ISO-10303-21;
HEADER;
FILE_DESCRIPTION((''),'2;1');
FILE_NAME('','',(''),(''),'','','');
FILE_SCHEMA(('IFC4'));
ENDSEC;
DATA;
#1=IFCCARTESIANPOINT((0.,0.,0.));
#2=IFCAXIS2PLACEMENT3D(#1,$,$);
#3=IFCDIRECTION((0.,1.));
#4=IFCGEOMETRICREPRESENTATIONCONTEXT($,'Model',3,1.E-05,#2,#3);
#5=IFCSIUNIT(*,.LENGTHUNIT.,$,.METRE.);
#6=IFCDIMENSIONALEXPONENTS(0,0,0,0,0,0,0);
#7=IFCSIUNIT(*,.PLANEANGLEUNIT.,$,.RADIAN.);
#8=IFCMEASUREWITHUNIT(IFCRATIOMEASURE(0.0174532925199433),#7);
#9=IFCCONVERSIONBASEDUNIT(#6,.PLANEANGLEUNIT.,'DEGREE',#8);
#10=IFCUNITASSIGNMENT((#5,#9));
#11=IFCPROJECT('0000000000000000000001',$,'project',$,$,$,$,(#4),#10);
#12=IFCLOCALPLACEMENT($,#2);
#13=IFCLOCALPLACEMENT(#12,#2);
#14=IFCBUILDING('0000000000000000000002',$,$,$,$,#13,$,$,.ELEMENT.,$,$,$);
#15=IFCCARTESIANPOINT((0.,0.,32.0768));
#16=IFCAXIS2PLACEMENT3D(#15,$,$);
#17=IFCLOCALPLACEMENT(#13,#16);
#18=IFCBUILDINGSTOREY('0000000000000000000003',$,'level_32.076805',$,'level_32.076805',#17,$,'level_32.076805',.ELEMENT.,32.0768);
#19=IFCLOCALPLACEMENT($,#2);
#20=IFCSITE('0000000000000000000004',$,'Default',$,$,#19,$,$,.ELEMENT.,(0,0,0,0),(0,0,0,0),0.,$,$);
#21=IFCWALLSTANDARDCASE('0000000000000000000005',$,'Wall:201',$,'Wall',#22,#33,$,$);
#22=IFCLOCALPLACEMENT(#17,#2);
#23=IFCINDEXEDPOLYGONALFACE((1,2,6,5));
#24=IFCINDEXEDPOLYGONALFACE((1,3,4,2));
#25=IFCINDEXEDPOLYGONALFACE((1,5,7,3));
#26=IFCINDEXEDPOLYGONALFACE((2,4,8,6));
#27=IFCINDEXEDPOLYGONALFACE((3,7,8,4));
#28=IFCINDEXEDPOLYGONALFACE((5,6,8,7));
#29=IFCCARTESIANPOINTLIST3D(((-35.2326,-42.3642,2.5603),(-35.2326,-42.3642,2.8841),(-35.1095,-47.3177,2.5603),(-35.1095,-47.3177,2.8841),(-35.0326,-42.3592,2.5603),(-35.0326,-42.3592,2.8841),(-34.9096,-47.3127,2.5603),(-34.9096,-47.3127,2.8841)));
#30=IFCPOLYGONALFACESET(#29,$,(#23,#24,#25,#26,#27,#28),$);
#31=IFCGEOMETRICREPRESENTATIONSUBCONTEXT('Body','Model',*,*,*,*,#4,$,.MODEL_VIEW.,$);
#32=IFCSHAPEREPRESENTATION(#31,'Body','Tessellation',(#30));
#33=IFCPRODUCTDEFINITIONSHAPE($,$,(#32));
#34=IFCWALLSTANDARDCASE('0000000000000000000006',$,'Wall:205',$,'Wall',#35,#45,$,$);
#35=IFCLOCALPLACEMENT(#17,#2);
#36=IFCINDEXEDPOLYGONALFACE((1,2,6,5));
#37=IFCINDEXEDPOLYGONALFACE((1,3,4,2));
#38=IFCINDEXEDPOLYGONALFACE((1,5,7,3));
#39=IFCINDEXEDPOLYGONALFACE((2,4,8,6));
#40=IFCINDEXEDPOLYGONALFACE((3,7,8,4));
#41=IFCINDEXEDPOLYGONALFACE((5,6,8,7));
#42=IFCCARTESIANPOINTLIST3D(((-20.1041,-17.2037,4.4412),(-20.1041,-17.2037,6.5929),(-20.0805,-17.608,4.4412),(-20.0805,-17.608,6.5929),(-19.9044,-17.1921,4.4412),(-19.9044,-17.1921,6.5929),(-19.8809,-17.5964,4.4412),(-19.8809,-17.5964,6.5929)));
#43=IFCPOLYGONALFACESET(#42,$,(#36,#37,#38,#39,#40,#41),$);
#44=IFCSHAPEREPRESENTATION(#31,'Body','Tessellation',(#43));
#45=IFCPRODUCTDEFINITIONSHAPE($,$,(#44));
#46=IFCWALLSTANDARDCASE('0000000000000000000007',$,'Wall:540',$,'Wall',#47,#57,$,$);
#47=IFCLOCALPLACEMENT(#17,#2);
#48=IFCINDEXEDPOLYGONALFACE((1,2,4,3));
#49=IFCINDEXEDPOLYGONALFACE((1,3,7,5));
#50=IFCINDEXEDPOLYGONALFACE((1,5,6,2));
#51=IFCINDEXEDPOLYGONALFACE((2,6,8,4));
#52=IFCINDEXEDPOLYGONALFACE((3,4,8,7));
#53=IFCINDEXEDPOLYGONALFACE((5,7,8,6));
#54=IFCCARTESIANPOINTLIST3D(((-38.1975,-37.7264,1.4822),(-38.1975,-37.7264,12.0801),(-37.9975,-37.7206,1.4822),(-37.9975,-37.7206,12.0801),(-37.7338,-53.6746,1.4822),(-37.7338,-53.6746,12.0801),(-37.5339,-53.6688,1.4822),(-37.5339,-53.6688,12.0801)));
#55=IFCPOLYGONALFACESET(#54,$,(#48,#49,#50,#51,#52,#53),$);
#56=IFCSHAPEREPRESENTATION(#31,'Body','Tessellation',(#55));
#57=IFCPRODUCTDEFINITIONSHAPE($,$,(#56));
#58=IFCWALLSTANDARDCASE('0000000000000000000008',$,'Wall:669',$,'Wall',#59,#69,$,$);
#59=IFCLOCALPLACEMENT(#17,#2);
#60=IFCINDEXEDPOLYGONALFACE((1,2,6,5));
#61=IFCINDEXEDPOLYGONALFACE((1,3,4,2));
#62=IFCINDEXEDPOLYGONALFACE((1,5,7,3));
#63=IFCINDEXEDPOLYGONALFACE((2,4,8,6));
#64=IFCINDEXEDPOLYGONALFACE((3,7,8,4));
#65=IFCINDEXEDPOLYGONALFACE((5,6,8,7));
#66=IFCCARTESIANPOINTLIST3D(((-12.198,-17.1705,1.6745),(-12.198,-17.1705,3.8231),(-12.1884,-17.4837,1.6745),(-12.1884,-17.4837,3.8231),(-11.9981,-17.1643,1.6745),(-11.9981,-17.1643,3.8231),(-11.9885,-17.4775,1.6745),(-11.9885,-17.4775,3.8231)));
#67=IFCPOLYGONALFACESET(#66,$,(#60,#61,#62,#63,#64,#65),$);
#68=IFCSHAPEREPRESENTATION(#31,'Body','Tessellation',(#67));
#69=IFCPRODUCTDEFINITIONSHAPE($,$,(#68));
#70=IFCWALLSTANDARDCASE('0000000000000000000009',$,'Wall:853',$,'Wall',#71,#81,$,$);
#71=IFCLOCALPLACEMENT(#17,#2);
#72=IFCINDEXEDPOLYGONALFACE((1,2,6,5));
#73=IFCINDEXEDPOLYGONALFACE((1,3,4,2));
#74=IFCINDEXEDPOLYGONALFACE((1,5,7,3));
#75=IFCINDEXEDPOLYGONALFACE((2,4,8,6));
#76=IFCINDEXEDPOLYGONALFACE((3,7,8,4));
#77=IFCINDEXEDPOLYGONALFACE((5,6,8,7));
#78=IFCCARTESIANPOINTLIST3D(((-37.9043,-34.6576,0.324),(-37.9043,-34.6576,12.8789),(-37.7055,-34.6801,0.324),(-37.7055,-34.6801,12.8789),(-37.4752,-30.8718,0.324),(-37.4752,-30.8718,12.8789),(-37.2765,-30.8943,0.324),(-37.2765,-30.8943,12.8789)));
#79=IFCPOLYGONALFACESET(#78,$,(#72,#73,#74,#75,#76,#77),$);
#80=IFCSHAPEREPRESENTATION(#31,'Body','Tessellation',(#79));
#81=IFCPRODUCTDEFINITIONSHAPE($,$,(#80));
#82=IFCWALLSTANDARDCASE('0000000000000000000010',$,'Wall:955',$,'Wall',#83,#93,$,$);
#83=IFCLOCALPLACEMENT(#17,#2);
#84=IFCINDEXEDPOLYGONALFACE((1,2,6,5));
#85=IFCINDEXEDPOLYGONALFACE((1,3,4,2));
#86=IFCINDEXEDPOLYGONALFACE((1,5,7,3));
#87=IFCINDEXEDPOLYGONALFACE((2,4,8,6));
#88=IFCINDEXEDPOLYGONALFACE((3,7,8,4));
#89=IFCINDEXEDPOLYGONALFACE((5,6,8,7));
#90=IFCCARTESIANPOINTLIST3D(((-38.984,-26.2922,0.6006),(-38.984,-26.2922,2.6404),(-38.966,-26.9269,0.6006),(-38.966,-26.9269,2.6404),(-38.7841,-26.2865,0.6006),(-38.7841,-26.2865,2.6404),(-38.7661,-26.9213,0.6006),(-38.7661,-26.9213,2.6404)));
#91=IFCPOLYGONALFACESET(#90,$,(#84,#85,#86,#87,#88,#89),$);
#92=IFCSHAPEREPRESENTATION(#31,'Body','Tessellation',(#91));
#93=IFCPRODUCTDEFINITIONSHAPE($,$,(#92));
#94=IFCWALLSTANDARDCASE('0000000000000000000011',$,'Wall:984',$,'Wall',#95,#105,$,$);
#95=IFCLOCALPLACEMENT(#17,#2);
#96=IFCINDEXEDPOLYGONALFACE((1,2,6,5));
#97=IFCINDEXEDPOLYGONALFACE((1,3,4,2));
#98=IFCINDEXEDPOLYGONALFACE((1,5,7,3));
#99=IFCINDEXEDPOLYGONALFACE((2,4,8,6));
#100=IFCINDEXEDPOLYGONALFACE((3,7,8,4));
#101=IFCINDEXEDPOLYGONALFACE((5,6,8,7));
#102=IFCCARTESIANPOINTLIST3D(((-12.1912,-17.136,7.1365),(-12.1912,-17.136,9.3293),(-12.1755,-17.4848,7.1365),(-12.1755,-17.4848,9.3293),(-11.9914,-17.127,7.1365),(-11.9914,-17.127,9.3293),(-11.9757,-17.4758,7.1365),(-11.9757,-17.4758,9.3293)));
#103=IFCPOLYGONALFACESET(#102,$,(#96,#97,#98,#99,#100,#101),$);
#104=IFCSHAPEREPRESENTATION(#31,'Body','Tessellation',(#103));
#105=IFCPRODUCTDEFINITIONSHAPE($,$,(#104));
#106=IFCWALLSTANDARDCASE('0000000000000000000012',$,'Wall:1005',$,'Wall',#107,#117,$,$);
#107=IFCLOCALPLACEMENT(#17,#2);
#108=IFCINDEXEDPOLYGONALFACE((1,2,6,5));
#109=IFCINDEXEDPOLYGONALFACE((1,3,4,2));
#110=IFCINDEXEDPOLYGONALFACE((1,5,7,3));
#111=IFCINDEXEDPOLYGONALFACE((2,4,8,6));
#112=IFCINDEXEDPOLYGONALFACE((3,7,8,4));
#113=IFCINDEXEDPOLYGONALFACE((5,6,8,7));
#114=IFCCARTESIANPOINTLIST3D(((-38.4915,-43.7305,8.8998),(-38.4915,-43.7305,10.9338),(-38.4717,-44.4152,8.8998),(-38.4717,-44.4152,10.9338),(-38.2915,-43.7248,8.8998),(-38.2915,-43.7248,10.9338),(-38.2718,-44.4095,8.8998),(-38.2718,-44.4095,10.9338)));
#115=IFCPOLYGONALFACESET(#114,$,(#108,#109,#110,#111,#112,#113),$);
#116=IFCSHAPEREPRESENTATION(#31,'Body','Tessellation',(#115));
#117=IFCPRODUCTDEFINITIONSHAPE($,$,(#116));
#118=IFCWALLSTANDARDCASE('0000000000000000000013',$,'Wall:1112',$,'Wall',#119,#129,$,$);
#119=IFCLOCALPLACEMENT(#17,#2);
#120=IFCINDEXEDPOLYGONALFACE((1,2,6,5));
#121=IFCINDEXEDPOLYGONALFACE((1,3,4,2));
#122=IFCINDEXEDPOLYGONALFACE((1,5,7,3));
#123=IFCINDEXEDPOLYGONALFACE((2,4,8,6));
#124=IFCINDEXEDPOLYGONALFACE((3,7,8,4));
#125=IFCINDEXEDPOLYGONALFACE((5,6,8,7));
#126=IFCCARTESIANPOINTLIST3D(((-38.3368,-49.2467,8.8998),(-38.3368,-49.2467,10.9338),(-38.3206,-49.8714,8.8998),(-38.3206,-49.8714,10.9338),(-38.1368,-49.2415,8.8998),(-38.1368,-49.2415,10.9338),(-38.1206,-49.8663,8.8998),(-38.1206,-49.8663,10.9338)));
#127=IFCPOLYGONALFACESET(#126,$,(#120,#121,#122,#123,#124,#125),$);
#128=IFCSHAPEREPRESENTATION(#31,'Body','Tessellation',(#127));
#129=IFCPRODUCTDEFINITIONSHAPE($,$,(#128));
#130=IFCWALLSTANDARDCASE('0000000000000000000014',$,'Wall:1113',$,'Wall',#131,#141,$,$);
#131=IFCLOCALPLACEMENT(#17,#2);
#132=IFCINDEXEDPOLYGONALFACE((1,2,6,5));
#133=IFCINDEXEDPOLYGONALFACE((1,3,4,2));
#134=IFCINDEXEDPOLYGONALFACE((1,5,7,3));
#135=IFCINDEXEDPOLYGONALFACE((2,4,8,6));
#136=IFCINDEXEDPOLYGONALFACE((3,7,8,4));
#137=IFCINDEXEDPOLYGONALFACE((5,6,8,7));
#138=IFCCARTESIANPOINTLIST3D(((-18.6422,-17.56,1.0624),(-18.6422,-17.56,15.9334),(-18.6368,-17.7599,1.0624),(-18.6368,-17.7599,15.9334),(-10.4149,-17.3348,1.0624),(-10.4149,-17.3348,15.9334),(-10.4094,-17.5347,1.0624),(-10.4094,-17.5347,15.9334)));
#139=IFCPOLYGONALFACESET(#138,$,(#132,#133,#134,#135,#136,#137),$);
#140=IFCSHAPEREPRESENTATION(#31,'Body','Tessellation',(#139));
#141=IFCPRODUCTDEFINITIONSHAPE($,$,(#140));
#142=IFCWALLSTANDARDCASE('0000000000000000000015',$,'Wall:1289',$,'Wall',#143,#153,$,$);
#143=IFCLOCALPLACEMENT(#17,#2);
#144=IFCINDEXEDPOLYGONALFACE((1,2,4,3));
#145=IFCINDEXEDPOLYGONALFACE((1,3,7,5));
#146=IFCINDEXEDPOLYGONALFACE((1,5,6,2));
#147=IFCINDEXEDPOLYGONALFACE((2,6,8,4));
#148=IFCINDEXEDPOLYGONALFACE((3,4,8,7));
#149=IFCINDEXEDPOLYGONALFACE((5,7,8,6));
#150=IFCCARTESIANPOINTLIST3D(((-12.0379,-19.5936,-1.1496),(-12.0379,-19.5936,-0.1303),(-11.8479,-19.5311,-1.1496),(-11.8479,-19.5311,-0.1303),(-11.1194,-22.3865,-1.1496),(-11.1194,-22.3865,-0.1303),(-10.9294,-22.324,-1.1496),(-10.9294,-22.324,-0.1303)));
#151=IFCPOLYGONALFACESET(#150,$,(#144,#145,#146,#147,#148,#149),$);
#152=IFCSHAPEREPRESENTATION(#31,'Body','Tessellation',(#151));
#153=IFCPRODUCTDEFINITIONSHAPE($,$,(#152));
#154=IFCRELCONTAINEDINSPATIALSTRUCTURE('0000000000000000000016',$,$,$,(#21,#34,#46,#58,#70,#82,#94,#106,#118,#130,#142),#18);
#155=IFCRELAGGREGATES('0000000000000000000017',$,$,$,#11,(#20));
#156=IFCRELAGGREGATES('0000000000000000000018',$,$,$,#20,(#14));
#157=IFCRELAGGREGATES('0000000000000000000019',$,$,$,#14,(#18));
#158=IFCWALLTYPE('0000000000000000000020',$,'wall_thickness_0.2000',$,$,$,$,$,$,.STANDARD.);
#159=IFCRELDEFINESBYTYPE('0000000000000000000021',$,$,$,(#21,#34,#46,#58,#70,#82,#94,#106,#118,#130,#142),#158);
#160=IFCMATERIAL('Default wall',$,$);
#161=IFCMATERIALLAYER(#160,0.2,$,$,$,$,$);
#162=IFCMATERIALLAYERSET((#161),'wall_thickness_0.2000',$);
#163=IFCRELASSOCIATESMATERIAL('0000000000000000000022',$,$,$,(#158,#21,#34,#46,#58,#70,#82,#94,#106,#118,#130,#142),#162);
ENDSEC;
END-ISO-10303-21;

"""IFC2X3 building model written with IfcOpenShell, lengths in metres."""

from ifc_helpers import new_model, entity, si_unit, converted_unit, direction, frame, origin, place, context, subcontext, project, spatial, polyline, outline, extrude, material, layer, layer_set, layer_usage, type_object, element, save


model = new_model("IFC2X3")

# Units and contexts
model_context = context("Model", 3, precision=1e-05, world=origin(), true_north=direction((0.0, 1.0)))
body_context = subcontext(model_context, "Body", "Model", "MODEL_VIEW")
ifc_project = project(units=[si_unit("LENGTHUNIT", "METRE"), converted_unit("PLANEANGLEUNIT", "DEGREE", entity("IfcRatioMeasure", 0.0174532925199433), si_unit("PLANEANGLEUNIT", "RADIAN"), dimensions=[0, 0, 0, 0, 0, 0, 0])], contexts=[model_context])

# Site, building, storey
site_placement = place(None, origin())
site = spatial("IfcSite", under=ifc_project, at=site_placement, Name="Default", CompositionType="ELEMENT", RefLatitude=(0, 0, 0, 0), RefLongitude=(0, 0, 0, 0), RefElevation=0.0)
placement_1 = place(None, origin())
building_placement = place(placement_1, origin())
building = spatial("IfcBuilding", under=site, at=building_placement, CompositionType="ELEMENT")
storey_placement = place(building_placement, frame((0.0, 0.0, 32.0768)))
storey = spatial("IfcBuildingStorey", under=building, at=storey_placement, Name="level_32.076805", ObjectType="level_32.076805", LongName="level_32.076805", CompositionType="ELEMENT", Elevation=32.0768)

# Walls
ifc_material_1 = material(Name="Default wall")
ifc_layer = layer(ifc_material_1, 0.2)
ifc_layer_set = layer_set([ifc_layer], Name="wall_thickness_0.2000")
ifc_layer_usage = layer_usage(ifc_layer_set, "AXIS2", "POSITIVE", -0.1)
wall_type = type_object("IfcWallType", Name="wall_thickness_0.2000", PredefinedType="STANDARD", material=ifc_layer_set)
placement_2 = place(building_placement, frame((0.0, 0.0, 34.6371)))
wall_1_placement = place(placement_2, frame((-35.1326, -42.3617, 0.0), z_axis=(0.0, 0.0, 1.0), x_axis=(0.024838, -0.999691, 0.0)))
element("IfcWallStandardCase", 1, at=wall_1_placement, inside=storey, type_object=wall_type, material=ifc_layer_usage, Name="Wall:201", ObjectType="Wall", context=body_context, shape_type="SweptSolid", body=[
    extrude(outline(polyline([(4.955, -0.1), (4.955, 0.1), (0.0, 0.1), (0.0, -0.1), (4.955, -0.1)])), origin(), (0.0, 0.0, 1.0), 0.3238),
])
placement_3 = place(building_placement, frame((0.0, 0.0, 36.518)))
wall_2_placement = place(placement_3, frame((-19.9807, -17.6022, 0.0), z_axis=(0.0, 0.0, 1.0), x_axis=(-0.058139, 0.998309, 0.0)))
element("IfcWallStandardCase", 2, at=wall_2_placement, inside=storey, type_object=wall_type, material=ifc_layer_usage, Name="Wall:205", ObjectType="Wall", context=body_context, shape_type="SweptSolid", body=[
    extrude(outline(polyline([(0.405, -0.1), (0.405, 0.1), (0.0, 0.1), (0.0, -0.1), (0.405, -0.1)])), origin(), (0.0, 0.0, 1.0), 2.1518),
])
placement_4 = place(building_placement, frame((0.0, 0.0, 33.559)))
wall_3_placement = place(placement_4, frame((-37.6338, -53.6717, 0.0), z_axis=(0.0, 0.0, 1.0), x_axis=(-0.029062, 0.999578, 0.0)))
element("IfcWallStandardCase", 3, at=wall_3_placement, inside=storey, type_object=wall_type, material=ifc_layer_usage, Name="Wall:540", ObjectType="Wall", context=body_context, shape_type="SweptSolid", body=[
    extrude(outline(polyline([(15.955, -0.1), (15.955, 0.1), (0.0, 0.1), (0.0, -0.1), (15.955, -0.1)])), origin(), (0.0, 0.0, 1.0), 10.5979),
])
placement_5 = place(building_placement, frame((0.0, 0.0, 33.7513)))
wall_4_placement = place(placement_5, frame((-12.0884, -17.4806, 0.0), z_axis=(0.0, 0.0, 1.0), x_axis=(-0.030669, 0.99953, 0.0)))
element("IfcWallStandardCase", 4, at=wall_4_placement, inside=storey, type_object=wall_type, material=ifc_layer_usage, Name="Wall:669", ObjectType="Wall", context=body_context, shape_type="SweptSolid", body=[
    extrude(outline(polyline([(0.3134, -0.1), (0.3134, 0.1), (0.0, 0.1), (0.0, -0.1), (0.3134, -0.1)])), origin(), (0.0, 0.0, 1.0), 2.1486),
])
placement_6 = place(building_placement, frame((0.0, 0.0, 32.4008)))
wall_5_placement = place(placement_6, frame((-37.8049, -34.6689, 0.0), z_axis=(0.0, 0.0, 1.0), x_axis=(0.112607, 0.99364, 0.0)))
element("IfcWallStandardCase", 5, at=wall_5_placement, inside=storey, type_object=wall_type, material=ifc_layer_usage, Name="Wall:853", ObjectType="Wall", context=body_context, shape_type="SweptSolid", body=[
    extrude(outline(polyline([(3.81, -0.1), (3.81, 0.1), (0.0, 0.1), (0.0, -0.1), (3.81, -0.1)])), origin(), (0.0, 0.0, 1.0), 12.5549),
])
placement_7 = place(building_placement, frame((0.0, 0.0, 32.6774)))
wall_6_placement = place(placement_7, frame((-38.8661, -26.9241, 0.0), z_axis=(0.0, 0.0, 1.0), x_axis=(-0.028271, 0.9996, 0.0)))
element("IfcWallStandardCase", 6, at=wall_6_placement, inside=storey, type_object=wall_type, material=ifc_layer_usage, Name="Wall:955", ObjectType="Wall", context=body_context, shape_type="SweptSolid", body=[
    extrude(outline(polyline([(0.635, -0.1), (0.635, 0.1), (0.0, 0.1), (0.0, -0.1), (0.635, -0.1)])), origin(), (0.0, 0.0, 1.0), 2.0398),
])
placement_8 = place(building_placement, frame((0.0, 0.0, 39.2133)))
wall_7_placement = place(placement_8, frame((-12.0756, -17.4803, 0.0), z_axis=(0.0, 0.0, 1.0), x_axis=(-0.045089, 0.998983, 0.0)))
element("IfcWallStandardCase", 7, at=wall_7_placement, inside=storey, type_object=wall_type, material=ifc_layer_usage, Name="Wall:984", ObjectType="Wall", context=body_context, shape_type="SweptSolid", body=[
    extrude(outline(polyline([(0.3491, -0.1), (0.3491, 0.1), (0.0, 0.1), (0.0, -0.1), (0.3491, -0.1)])), origin(), (0.0, 0.0, 1.0), 2.1928),
])
placement_9 = place(building_placement, frame((0.0, 0.0, 40.9766)))
wall_8_placement = place(placement_9, frame((-38.3717, -44.4124, 0.0), z_axis=(0.0, 0.0, 1.0), x_axis=(-0.02883, 0.999584, 0.0)))
element("IfcWallStandardCase", 8, at=wall_8_placement, inside=storey, type_object=wall_type, material=ifc_layer_usage, Name="Wall:1005", ObjectType="Wall", context=body_context, shape_type="SweptSolid", body=[
    extrude(outline(polyline([(0.685, -0.1), (0.685, 0.1), (0.0, 0.1), (0.0, -0.1), (0.685, -0.1)])), origin(), (0.0, 0.0, 1.0), 2.034),
])
placement_10 = place(building_placement, frame((0.0, 0.0, 40.9766)))
wall_9_placement = place(placement_10, frame((-38.2368, -49.2441, 0.0), z_axis=(0.0, 0.0, 1.0), x_axis=(0.025897, -0.999665, 0.0)))
element("IfcWallStandardCase", 9, at=wall_9_placement, inside=storey, type_object=wall_type, material=ifc_layer_usage, Name="Wall:1112", ObjectType="Wall", context=body_context, shape_type="SweptSolid", body=[
    extrude(outline(polyline([(0.625, -0.1), (0.625, 0.1), (0.0, 0.1), (0.0, -0.1), (0.625, -0.1)])), origin(), (0.0, 0.0, 1.0), 2.034),
])
placement_11 = place(building_placement, frame((0.0, 0.0, 33.1392)))
wall_10_placement = place(placement_11, frame((-10.4121, -17.4347, 0.0), z_axis=(0.0, 0.0, 1.0), x_axis=(-0.999626, -0.027361, 0.0)))
element("IfcWallStandardCase", 10, at=wall_10_placement, inside=storey, type_object=wall_type, material=ifc_layer_usage, Name="Wall:1113", ObjectType="Wall", context=body_context, shape_type="SweptSolid", body=[
    extrude(outline(polyline([(8.2304, -0.1), (8.2304, 0.1), (0.0, 0.1), (0.0, -0.1), (8.2304, -0.1)])), origin(), (0.0, 0.0, 1.0), 14.871),
])
placement_12 = place(building_placement, frame((0.0, 0.0, 30.9272)))
wall_11_placement = place(placement_12, frame((-11.9429, -19.5624, 0.0), z_axis=(0.0, 0.0, 1.0), x_axis=(0.312404, -0.949949, 0.0)))
element("IfcWallStandardCase", 11, at=wall_11_placement, inside=storey, type_object=wall_type, material=ifc_layer_usage, Name="Wall:1289", ObjectType="Wall", context=body_context, shape_type="SweptSolid", body=[
    extrude(outline(polyline([(2.94, -0.1), (2.94, 0.1), (0.0, 0.1), (0.0, -0.1), (2.94, -0.1)])), origin(), (0.0, 0.0, 1.0), 1.0194),
])

save(model, "model.ifc")
